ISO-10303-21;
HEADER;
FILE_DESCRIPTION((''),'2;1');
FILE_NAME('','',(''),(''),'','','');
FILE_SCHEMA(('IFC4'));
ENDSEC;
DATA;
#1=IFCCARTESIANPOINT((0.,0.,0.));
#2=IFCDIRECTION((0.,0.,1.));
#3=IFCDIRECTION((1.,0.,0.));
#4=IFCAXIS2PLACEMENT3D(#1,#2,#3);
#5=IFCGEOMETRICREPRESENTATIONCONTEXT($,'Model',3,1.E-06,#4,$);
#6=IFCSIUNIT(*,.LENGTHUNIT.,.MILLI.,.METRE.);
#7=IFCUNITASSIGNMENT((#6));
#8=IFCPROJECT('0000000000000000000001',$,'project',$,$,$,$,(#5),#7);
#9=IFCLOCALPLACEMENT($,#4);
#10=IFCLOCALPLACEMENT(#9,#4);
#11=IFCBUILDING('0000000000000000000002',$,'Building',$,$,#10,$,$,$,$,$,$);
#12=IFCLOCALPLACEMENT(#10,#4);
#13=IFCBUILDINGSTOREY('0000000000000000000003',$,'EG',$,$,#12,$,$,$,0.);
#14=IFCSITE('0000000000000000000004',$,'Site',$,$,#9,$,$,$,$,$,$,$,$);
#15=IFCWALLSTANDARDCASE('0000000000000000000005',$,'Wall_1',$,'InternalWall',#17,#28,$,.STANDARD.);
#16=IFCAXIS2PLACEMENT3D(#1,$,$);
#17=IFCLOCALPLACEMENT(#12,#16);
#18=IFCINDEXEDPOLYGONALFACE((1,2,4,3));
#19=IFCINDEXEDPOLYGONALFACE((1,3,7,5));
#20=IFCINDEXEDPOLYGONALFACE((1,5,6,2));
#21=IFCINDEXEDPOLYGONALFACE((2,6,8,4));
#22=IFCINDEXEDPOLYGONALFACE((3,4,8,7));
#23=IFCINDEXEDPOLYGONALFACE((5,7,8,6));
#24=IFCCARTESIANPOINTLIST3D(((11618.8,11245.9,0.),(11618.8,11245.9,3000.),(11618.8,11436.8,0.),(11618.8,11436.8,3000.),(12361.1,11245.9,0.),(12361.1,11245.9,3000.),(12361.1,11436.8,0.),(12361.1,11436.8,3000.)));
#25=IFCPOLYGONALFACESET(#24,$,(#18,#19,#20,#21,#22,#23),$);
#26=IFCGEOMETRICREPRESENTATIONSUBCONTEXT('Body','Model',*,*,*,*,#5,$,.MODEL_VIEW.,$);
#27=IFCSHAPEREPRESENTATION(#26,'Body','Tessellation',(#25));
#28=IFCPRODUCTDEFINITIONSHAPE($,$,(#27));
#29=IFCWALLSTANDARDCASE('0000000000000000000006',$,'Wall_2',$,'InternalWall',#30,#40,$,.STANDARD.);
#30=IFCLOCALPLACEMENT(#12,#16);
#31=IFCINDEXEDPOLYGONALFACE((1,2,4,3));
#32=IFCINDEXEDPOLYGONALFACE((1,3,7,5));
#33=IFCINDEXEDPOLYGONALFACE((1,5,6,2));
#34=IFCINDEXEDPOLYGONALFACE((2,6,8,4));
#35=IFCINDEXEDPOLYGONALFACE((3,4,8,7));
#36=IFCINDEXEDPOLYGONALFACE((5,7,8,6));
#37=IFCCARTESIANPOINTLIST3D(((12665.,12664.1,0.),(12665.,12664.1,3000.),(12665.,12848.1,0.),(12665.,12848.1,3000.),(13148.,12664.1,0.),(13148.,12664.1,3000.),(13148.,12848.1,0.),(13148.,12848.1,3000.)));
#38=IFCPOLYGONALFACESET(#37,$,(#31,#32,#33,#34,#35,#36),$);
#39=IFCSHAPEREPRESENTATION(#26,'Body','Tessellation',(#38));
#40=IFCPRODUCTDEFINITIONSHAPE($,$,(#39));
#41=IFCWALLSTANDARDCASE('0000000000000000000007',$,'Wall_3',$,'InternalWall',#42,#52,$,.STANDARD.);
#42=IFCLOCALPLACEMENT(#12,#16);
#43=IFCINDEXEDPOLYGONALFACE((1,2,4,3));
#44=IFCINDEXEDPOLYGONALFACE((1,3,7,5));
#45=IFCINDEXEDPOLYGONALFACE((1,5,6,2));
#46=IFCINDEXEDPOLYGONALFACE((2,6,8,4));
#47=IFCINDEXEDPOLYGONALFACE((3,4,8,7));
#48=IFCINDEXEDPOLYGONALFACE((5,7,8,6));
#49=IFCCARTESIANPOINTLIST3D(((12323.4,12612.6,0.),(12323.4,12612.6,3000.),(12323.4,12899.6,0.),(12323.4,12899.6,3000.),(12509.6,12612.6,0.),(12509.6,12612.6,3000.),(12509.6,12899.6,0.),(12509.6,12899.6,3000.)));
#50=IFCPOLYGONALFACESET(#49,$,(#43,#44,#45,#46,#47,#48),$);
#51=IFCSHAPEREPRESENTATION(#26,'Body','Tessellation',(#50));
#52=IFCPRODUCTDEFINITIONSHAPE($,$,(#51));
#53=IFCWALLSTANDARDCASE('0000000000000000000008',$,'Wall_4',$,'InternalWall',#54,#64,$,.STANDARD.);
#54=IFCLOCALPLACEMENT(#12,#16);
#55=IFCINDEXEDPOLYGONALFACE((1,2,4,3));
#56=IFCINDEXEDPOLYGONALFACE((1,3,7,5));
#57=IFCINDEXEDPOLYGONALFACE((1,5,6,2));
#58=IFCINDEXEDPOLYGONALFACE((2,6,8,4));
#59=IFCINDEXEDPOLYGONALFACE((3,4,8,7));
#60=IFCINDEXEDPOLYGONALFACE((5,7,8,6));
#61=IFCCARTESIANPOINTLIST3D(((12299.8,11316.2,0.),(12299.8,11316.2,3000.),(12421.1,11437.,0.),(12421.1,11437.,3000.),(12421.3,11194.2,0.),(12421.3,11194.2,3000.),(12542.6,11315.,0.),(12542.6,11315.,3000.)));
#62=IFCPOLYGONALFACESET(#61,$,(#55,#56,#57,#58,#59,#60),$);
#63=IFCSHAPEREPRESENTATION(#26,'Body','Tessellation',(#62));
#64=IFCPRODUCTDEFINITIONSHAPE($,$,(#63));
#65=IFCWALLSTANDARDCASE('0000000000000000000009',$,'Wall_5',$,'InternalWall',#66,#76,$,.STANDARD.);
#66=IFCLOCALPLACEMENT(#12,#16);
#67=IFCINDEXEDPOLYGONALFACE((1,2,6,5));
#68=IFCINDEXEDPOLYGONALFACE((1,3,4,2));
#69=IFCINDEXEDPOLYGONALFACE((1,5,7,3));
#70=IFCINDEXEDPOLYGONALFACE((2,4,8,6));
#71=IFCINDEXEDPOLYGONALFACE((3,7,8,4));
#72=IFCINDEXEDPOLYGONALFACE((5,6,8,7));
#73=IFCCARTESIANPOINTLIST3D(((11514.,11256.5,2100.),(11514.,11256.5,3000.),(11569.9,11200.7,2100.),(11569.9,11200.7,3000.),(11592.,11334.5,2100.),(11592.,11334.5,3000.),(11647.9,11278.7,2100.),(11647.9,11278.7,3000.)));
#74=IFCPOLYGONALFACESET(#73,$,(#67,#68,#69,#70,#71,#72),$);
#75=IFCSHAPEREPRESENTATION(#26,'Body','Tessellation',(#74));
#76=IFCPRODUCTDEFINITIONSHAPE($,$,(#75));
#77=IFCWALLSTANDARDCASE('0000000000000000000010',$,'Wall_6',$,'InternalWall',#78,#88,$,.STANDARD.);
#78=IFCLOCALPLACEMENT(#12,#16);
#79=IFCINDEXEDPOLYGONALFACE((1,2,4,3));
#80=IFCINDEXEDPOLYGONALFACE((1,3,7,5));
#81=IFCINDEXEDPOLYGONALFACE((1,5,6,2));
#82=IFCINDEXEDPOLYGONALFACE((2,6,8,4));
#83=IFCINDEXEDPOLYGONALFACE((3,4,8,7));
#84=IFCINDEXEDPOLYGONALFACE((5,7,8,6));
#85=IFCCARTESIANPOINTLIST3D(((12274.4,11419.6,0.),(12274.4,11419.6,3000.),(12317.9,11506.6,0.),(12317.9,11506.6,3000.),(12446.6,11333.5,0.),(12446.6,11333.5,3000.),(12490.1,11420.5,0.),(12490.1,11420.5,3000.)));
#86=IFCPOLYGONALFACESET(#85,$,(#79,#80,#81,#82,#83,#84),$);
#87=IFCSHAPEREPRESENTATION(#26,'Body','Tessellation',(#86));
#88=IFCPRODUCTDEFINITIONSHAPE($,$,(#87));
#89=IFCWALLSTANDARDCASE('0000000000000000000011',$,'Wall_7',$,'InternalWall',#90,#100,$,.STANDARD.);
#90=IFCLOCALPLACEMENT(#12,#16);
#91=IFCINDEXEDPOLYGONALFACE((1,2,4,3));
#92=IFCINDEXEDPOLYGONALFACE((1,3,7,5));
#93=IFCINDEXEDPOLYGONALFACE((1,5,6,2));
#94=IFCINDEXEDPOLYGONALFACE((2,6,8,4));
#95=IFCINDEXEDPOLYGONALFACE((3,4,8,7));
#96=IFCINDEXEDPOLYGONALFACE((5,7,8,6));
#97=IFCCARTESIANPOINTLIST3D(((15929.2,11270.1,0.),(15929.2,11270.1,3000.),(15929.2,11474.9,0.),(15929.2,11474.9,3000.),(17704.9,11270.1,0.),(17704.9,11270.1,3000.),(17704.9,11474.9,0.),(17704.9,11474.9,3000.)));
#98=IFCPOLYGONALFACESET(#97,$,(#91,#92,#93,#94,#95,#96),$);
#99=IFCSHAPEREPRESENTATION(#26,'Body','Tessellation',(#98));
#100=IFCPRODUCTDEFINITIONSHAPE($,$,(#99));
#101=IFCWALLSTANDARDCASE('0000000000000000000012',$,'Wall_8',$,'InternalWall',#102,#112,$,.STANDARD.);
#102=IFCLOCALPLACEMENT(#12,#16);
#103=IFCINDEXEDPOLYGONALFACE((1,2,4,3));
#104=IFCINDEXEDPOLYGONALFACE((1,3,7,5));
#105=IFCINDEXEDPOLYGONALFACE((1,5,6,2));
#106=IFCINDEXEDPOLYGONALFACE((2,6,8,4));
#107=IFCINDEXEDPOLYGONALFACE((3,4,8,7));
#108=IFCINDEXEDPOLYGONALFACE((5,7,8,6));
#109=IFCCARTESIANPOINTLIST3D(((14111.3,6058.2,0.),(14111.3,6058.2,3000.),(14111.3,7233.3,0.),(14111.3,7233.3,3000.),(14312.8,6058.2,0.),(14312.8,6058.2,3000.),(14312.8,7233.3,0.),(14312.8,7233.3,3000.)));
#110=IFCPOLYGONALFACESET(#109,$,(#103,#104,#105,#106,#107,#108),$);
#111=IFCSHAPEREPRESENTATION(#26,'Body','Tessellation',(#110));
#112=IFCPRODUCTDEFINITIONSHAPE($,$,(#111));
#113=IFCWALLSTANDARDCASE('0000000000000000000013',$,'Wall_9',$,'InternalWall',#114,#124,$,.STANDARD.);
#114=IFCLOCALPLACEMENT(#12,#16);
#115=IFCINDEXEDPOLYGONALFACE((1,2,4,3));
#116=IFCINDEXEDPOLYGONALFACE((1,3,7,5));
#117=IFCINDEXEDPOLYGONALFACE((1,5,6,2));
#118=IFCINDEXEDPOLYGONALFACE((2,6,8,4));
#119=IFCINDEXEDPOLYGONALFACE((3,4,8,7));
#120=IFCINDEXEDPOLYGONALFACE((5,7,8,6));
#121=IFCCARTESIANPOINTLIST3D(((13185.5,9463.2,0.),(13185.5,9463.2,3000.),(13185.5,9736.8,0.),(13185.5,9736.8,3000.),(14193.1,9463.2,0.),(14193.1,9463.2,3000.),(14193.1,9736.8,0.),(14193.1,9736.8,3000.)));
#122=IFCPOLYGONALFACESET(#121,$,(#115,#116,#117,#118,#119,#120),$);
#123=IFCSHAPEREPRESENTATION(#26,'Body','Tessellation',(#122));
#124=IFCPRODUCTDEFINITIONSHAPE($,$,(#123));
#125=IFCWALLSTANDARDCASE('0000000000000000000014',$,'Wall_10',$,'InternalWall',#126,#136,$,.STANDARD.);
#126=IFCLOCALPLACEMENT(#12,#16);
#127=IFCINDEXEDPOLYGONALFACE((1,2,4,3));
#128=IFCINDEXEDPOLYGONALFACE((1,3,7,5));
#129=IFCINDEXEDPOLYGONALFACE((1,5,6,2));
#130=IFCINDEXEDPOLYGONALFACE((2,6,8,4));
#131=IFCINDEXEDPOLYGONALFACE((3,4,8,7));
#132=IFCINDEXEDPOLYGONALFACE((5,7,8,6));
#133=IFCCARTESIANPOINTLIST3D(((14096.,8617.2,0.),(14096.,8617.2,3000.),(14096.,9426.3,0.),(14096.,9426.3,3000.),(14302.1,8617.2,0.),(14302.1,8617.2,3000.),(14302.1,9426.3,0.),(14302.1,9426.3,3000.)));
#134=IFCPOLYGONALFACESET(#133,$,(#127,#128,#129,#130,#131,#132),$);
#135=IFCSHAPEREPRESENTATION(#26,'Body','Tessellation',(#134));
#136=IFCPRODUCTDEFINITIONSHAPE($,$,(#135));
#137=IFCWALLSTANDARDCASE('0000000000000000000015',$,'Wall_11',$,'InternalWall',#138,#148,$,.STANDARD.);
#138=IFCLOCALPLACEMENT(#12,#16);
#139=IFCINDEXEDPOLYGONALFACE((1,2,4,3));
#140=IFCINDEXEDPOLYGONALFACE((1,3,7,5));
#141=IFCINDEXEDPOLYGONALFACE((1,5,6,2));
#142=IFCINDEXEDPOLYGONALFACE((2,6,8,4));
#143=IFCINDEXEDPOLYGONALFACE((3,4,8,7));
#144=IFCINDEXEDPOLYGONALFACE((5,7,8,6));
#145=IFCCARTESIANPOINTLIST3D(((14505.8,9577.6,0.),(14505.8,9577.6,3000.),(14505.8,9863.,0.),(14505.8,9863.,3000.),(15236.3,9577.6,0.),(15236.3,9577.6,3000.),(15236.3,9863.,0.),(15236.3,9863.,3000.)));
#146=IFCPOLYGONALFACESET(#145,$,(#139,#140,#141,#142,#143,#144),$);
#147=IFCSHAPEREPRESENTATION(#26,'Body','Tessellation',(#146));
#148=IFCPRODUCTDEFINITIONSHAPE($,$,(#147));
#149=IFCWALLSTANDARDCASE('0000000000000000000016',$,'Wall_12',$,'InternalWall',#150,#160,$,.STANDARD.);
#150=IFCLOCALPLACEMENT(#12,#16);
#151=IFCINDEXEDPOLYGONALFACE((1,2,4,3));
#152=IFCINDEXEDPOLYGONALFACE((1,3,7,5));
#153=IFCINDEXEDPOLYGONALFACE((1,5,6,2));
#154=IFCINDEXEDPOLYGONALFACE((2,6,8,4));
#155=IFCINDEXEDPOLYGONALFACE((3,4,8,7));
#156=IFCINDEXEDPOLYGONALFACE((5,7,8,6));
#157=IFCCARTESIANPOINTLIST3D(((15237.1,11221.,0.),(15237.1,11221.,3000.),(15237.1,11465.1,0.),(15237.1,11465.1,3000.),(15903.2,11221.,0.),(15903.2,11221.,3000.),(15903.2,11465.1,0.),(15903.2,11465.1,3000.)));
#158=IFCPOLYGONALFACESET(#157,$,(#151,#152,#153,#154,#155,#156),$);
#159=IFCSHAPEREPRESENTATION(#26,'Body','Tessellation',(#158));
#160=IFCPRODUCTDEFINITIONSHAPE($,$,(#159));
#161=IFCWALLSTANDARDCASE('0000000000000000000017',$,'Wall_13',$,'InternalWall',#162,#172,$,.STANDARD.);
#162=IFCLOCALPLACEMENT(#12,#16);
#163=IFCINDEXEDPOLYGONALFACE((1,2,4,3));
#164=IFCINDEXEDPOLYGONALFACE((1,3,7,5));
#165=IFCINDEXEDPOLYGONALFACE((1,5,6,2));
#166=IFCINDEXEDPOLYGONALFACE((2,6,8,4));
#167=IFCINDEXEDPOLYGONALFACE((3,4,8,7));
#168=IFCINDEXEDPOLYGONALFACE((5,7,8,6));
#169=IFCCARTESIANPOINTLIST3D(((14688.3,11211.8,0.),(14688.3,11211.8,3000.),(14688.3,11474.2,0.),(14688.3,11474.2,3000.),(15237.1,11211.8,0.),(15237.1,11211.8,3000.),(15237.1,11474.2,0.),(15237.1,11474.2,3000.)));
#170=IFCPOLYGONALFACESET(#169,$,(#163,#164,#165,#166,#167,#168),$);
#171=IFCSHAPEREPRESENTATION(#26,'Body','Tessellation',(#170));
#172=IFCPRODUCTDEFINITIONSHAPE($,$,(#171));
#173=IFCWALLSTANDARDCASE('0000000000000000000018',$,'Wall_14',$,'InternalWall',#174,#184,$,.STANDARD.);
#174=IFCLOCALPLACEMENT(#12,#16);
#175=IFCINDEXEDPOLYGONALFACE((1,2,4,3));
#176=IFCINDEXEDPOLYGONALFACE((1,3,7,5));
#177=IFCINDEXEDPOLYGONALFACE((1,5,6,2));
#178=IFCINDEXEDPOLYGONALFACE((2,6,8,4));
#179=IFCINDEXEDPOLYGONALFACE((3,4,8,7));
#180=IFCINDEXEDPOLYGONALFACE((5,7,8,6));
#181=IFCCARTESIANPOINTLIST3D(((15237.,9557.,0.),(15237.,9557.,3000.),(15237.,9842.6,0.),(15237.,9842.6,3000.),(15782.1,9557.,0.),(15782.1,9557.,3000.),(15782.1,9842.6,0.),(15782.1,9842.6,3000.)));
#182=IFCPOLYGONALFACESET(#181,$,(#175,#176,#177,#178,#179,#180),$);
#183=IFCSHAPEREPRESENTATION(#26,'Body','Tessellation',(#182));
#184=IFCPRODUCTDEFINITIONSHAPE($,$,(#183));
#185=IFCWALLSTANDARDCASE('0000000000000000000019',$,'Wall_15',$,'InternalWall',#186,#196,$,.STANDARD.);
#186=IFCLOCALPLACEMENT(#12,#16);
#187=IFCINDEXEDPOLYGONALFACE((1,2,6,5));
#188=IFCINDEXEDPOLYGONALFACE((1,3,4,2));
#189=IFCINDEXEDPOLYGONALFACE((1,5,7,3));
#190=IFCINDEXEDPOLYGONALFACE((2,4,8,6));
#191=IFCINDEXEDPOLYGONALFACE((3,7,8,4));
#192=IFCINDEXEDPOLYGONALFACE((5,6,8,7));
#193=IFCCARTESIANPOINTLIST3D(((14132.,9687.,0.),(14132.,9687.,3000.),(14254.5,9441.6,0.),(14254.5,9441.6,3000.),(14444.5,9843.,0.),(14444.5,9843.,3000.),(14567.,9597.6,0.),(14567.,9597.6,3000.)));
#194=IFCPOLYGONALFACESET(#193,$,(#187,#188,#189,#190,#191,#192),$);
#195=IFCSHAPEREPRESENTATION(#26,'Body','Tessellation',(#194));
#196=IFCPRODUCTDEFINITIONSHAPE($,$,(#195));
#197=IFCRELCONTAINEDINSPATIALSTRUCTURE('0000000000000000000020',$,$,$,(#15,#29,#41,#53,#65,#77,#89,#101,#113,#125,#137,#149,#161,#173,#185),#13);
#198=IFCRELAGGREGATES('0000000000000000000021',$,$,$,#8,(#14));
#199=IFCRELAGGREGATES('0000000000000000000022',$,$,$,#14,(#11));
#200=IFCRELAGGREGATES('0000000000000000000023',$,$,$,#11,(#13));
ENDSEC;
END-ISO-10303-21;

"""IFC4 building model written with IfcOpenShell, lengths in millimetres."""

from ifc_helpers import new_model, si_unit, frame, origin_with_axes, place, context, subcontext, project, spatial, rectangle, extrude, element, save


model = new_model("IFC4")

# Units and contexts
model_context = context("Model", 3, precision=1e-06, world=origin_with_axes())
body_context = subcontext(model_context, "Body", "Model", "MODEL_VIEW")
ifc_project = project(units=[si_unit("LENGTHUNIT", "METRE", prefix="MILLI")], contexts=[model_context])

# Site, building, storey
site_placement = place(None, origin_with_axes())
site = spatial("IfcSite", under=ifc_project, at=site_placement, Name="Site")
building_placement = place(site_placement, origin_with_axes())
building = spatial("IfcBuilding", under=site, at=building_placement, Name="Building")
storey_placement = place(building_placement, origin_with_axes())
storey = spatial("IfcBuildingStorey", under=building, at=storey_placement, Name="EG", Elevation=0.0)

# Walls
wall_1_placement = place(storey_placement, origin_with_axes())
element("IfcWallStandardCase", 1, at=wall_1_placement, inside=storey, Name="Wall_1", ObjectType="InternalWall", PredefinedType="STANDARD", context=body_context, shape_type="SweptSolid", body=[
    extrude(rectangle(XDim=742.3, YDim=190.8), frame((11990.0, 11341.3, 0.0), z_axis=(0.0, 0.0, 1.0), x_axis=(-1.0, 0.0, 0.0)), (0.0, 0.0, 1.0), 3000.0),
])
wall_2_placement = place(storey_placement, origin_with_axes())
element("IfcWallStandardCase", 2, at=wall_2_placement, inside=storey, Name="Wall_2", ObjectType="InternalWall", PredefinedType="STANDARD", context=body_context, shape_type="SweptSolid", body=[
    extrude(rectangle(XDim=483.0, YDim=184.0), frame((12906.5, 12756.1, 0.0), z_axis=(0.0, 0.0, 1.0), x_axis=(-1.0, 0.0, 0.0)), (0.0, 0.0, 1.0), 3000.0),
])
wall_3_placement = place(storey_placement, origin_with_axes())
element("IfcWallStandardCase", 3, at=wall_3_placement, inside=storey, Name="Wall_3", ObjectType="InternalWall", PredefinedType="STANDARD", context=body_context, shape_type="SweptSolid", body=[
    extrude(rectangle(XDim=287.0, YDim=186.2), frame((12416.5, 12756.1, 0.0), z_axis=(0.0, 0.0, 1.0), x_axis=(0.0, -1.0, 0.0)), (0.0, 0.0, 1.0), 3000.0),
])
wall_4_placement = place(storey_placement, origin_with_axes())
element("IfcWallStandardCase", 4, at=wall_4_placement, inside=storey, Name="Wall_4", ObjectType="InternalWall", PredefinedType="STANDARD", context=body_context, shape_type="SweptSolid", body=[
    extrude(rectangle(XDim=172.2, YDim=171.3), frame((12421.2, 11315.6, 0.0), z_axis=(0.0, 0.0, 1.0), x_axis=(0.705653, -0.708557, 0.0)), (0.0, 0.0, 1.0), 3000.0),
])

# Wall, opening
wall_5_placement = place(storey_placement, origin_with_axes())
wall_5 = element("IfcWallStandardCase", 5, at=wall_5_placement, inside=storey, Name="Wall_5", ObjectType="InternalWall", PredefinedType="STANDARD", context=body_context, shape_type="SweptSolid", body=[
    extrude(rectangle(XDim=110.3, YDim=79.0), frame((11581.0, 11267.6, 0.0), z_axis=(0.0, 0.0, 1.0), x_axis=(-0.707107, -0.707107, 0.0)), (0.0, 0.0, 1.0), 3000.0),
])
opening_1_placement = place(wall_5_placement, origin_with_axes())
element("IfcOpeningElement", 6, at=opening_1_placement, inside=storey, cuts=wall_5, context=body_context, shape_type="SweptSolid", body=[
    extrude(rectangle(XDim=450.0, YDim=79.0), frame((11581.0, 11267.6, 0.0), z_axis=(0.0, 0.0, 1.0), x_axis=(-0.707107, -0.707107, 0.0)), (0.0, 0.0, 1.0), 2100.0),
])

# Walls
wall_6_placement = place(storey_placement, origin_with_axes())
element("IfcWallStandardCase", 7, at=wall_6_placement, inside=storey, Name="Wall_6", ObjectType="InternalWall", PredefinedType="STANDARD", context=body_context, shape_type="SweptSolid", body=[
    extrude(rectangle(XDim=97.3, YDim=192.5), frame((12382.2, 11420.1, 0.0), z_axis=(0.0, 0.0, 1.0), x_axis=(-0.447214, -0.894427, 0.0)), (0.0, 0.0, 1.0), 3000.0),
])
wall_7_placement = place(storey_placement, origin_with_axes())
element("IfcWallStandardCase", 8, at=wall_7_placement, inside=storey, Name="Wall_7", ObjectType="InternalWall", PredefinedType="STANDARD", context=body_context, shape_type="SweptSolid", body=[
    extrude(rectangle(XDim=1775.7, YDim=204.8), frame((16817.0, 11372.5, 0.0), z_axis=(0.0, 0.0, 1.0), x_axis=(-1.0, 0.0, 0.0)), (0.0, 0.0, 1.0), 3000.0),
])
wall_8_placement = place(storey_placement, origin_with_axes())
element("IfcWallStandardCase", 9, at=wall_8_placement, inside=storey, Name="Wall_8", ObjectType="InternalWall", PredefinedType="STANDARD", context=body_context, shape_type="SweptSolid", body=[
    extrude(rectangle(XDim=1175.1, YDim=201.5), frame((14212.0, 6645.8, 0.0), z_axis=(0.0, 0.0, 1.0), x_axis=(0.0, -1.0, 0.0)), (0.0, 0.0, 1.0), 3000.0),
])
wall_9_placement = place(storey_placement, origin_with_axes())
element("IfcWallStandardCase", 10, at=wall_9_placement, inside=storey, Name="Wall_9", ObjectType="InternalWall", PredefinedType="STANDARD", context=body_context, shape_type="SweptSolid", body=[
    extrude(rectangle(XDim=1007.5, YDim=273.6), frame((13689.3, 9600.0, 0.0), z_axis=(0.0, 0.0, 1.0), x_axis=(-1.0, 0.0, 0.0)), (0.0, 0.0, 1.0), 3000.0),
])
wall_10_placement = place(storey_placement, origin_with_axes())
element("IfcWallStandardCase", 11, at=wall_10_placement, inside=storey, Name="Wall_10", ObjectType="InternalWall", PredefinedType="STANDARD", context=body_context, shape_type="SweptSolid", body=[
    extrude(rectangle(XDim=809.1, YDim=206.1), frame((14199.0, 9021.8, 0.0), z_axis=(0.0, 0.0, 1.0), x_axis=(0.0, 1.0, 0.0)), (0.0, 0.0, 1.0), 3000.0),
])
wall_11_placement = place(storey_placement, origin_with_axes())
element("IfcWallStandardCase", 12, at=wall_11_placement, inside=storey, Name="Wall_11", ObjectType="InternalWall", PredefinedType="STANDARD", context=body_context, shape_type="SweptSolid", body=[
    extrude(rectangle(XDim=730.5, YDim=285.4), frame((14871.0, 9720.3, 0.0), z_axis=(0.0, 0.0, 1.0), x_axis=(-1.0, 0.0, 0.0)), (0.0, 0.0, 1.0), 3000.0),
])
wall_12_placement = place(storey_placement, origin_with_axes())
element("IfcWallStandardCase", 13, at=wall_12_placement, inside=storey, Name="Wall_12", ObjectType="InternalWall", PredefinedType="STANDARD", context=body_context, shape_type="SweptSolid", body=[
    extrude(rectangle(XDim=666.1, YDim=244.0), frame((15570.1, 11343.0, 0.0), z_axis=(0.0, 0.0, 1.0), x_axis=(-1.0, 0.0, 0.0)), (0.0, 0.0, 1.0), 3000.0),
])
wall_13_placement = place(storey_placement, origin_with_axes())
element("IfcWallStandardCase", 14, at=wall_13_placement, inside=storey, Name="Wall_13", ObjectType="InternalWall", PredefinedType="STANDARD", context=body_context, shape_type="SweptSolid", body=[
    extrude(rectangle(XDim=548.8, YDim=262.4), frame((14962.7, 11343.0, 0.0), z_axis=(0.0, 0.0, 1.0), x_axis=(-1.0, 0.0, 0.0)), (0.0, 0.0, 1.0), 3000.0),
])
wall_14_placement = place(storey_placement, origin_with_axes())
element("IfcWallStandardCase", 15, at=wall_14_placement, inside=storey, Name="Wall_14", ObjectType="InternalWall", PredefinedType="STANDARD", context=body_context, shape_type="SweptSolid", body=[
    extrude(rectangle(XDim=545.0, YDim=285.5), frame((15509.5, 9699.8, 0.0), z_axis=(0.0, 0.0, 1.0), x_axis=(1.0, 0.0, 0.0)), (0.0, 0.0, 1.0), 3000.0),
])
wall_15_placement = place(storey_placement, origin_with_axes())
element("IfcWallStandardCase", 16, at=wall_15_placement, inside=storey, Name="Wall_15", ObjectType="InternalWall", PredefinedType="STANDARD", context=body_context, shape_type="SweptSolid", body=[
    extrude(rectangle(XDim=349.3, YDim=274.3), frame((14349.5, 9642.3, 0.0), z_axis=(0.0, 0.0, 1.0), x_axis=(-0.894713, -0.446641, 0.0)), (0.0, 0.0, 1.0), 3000.0),
])

save(model, "model.ifc")
